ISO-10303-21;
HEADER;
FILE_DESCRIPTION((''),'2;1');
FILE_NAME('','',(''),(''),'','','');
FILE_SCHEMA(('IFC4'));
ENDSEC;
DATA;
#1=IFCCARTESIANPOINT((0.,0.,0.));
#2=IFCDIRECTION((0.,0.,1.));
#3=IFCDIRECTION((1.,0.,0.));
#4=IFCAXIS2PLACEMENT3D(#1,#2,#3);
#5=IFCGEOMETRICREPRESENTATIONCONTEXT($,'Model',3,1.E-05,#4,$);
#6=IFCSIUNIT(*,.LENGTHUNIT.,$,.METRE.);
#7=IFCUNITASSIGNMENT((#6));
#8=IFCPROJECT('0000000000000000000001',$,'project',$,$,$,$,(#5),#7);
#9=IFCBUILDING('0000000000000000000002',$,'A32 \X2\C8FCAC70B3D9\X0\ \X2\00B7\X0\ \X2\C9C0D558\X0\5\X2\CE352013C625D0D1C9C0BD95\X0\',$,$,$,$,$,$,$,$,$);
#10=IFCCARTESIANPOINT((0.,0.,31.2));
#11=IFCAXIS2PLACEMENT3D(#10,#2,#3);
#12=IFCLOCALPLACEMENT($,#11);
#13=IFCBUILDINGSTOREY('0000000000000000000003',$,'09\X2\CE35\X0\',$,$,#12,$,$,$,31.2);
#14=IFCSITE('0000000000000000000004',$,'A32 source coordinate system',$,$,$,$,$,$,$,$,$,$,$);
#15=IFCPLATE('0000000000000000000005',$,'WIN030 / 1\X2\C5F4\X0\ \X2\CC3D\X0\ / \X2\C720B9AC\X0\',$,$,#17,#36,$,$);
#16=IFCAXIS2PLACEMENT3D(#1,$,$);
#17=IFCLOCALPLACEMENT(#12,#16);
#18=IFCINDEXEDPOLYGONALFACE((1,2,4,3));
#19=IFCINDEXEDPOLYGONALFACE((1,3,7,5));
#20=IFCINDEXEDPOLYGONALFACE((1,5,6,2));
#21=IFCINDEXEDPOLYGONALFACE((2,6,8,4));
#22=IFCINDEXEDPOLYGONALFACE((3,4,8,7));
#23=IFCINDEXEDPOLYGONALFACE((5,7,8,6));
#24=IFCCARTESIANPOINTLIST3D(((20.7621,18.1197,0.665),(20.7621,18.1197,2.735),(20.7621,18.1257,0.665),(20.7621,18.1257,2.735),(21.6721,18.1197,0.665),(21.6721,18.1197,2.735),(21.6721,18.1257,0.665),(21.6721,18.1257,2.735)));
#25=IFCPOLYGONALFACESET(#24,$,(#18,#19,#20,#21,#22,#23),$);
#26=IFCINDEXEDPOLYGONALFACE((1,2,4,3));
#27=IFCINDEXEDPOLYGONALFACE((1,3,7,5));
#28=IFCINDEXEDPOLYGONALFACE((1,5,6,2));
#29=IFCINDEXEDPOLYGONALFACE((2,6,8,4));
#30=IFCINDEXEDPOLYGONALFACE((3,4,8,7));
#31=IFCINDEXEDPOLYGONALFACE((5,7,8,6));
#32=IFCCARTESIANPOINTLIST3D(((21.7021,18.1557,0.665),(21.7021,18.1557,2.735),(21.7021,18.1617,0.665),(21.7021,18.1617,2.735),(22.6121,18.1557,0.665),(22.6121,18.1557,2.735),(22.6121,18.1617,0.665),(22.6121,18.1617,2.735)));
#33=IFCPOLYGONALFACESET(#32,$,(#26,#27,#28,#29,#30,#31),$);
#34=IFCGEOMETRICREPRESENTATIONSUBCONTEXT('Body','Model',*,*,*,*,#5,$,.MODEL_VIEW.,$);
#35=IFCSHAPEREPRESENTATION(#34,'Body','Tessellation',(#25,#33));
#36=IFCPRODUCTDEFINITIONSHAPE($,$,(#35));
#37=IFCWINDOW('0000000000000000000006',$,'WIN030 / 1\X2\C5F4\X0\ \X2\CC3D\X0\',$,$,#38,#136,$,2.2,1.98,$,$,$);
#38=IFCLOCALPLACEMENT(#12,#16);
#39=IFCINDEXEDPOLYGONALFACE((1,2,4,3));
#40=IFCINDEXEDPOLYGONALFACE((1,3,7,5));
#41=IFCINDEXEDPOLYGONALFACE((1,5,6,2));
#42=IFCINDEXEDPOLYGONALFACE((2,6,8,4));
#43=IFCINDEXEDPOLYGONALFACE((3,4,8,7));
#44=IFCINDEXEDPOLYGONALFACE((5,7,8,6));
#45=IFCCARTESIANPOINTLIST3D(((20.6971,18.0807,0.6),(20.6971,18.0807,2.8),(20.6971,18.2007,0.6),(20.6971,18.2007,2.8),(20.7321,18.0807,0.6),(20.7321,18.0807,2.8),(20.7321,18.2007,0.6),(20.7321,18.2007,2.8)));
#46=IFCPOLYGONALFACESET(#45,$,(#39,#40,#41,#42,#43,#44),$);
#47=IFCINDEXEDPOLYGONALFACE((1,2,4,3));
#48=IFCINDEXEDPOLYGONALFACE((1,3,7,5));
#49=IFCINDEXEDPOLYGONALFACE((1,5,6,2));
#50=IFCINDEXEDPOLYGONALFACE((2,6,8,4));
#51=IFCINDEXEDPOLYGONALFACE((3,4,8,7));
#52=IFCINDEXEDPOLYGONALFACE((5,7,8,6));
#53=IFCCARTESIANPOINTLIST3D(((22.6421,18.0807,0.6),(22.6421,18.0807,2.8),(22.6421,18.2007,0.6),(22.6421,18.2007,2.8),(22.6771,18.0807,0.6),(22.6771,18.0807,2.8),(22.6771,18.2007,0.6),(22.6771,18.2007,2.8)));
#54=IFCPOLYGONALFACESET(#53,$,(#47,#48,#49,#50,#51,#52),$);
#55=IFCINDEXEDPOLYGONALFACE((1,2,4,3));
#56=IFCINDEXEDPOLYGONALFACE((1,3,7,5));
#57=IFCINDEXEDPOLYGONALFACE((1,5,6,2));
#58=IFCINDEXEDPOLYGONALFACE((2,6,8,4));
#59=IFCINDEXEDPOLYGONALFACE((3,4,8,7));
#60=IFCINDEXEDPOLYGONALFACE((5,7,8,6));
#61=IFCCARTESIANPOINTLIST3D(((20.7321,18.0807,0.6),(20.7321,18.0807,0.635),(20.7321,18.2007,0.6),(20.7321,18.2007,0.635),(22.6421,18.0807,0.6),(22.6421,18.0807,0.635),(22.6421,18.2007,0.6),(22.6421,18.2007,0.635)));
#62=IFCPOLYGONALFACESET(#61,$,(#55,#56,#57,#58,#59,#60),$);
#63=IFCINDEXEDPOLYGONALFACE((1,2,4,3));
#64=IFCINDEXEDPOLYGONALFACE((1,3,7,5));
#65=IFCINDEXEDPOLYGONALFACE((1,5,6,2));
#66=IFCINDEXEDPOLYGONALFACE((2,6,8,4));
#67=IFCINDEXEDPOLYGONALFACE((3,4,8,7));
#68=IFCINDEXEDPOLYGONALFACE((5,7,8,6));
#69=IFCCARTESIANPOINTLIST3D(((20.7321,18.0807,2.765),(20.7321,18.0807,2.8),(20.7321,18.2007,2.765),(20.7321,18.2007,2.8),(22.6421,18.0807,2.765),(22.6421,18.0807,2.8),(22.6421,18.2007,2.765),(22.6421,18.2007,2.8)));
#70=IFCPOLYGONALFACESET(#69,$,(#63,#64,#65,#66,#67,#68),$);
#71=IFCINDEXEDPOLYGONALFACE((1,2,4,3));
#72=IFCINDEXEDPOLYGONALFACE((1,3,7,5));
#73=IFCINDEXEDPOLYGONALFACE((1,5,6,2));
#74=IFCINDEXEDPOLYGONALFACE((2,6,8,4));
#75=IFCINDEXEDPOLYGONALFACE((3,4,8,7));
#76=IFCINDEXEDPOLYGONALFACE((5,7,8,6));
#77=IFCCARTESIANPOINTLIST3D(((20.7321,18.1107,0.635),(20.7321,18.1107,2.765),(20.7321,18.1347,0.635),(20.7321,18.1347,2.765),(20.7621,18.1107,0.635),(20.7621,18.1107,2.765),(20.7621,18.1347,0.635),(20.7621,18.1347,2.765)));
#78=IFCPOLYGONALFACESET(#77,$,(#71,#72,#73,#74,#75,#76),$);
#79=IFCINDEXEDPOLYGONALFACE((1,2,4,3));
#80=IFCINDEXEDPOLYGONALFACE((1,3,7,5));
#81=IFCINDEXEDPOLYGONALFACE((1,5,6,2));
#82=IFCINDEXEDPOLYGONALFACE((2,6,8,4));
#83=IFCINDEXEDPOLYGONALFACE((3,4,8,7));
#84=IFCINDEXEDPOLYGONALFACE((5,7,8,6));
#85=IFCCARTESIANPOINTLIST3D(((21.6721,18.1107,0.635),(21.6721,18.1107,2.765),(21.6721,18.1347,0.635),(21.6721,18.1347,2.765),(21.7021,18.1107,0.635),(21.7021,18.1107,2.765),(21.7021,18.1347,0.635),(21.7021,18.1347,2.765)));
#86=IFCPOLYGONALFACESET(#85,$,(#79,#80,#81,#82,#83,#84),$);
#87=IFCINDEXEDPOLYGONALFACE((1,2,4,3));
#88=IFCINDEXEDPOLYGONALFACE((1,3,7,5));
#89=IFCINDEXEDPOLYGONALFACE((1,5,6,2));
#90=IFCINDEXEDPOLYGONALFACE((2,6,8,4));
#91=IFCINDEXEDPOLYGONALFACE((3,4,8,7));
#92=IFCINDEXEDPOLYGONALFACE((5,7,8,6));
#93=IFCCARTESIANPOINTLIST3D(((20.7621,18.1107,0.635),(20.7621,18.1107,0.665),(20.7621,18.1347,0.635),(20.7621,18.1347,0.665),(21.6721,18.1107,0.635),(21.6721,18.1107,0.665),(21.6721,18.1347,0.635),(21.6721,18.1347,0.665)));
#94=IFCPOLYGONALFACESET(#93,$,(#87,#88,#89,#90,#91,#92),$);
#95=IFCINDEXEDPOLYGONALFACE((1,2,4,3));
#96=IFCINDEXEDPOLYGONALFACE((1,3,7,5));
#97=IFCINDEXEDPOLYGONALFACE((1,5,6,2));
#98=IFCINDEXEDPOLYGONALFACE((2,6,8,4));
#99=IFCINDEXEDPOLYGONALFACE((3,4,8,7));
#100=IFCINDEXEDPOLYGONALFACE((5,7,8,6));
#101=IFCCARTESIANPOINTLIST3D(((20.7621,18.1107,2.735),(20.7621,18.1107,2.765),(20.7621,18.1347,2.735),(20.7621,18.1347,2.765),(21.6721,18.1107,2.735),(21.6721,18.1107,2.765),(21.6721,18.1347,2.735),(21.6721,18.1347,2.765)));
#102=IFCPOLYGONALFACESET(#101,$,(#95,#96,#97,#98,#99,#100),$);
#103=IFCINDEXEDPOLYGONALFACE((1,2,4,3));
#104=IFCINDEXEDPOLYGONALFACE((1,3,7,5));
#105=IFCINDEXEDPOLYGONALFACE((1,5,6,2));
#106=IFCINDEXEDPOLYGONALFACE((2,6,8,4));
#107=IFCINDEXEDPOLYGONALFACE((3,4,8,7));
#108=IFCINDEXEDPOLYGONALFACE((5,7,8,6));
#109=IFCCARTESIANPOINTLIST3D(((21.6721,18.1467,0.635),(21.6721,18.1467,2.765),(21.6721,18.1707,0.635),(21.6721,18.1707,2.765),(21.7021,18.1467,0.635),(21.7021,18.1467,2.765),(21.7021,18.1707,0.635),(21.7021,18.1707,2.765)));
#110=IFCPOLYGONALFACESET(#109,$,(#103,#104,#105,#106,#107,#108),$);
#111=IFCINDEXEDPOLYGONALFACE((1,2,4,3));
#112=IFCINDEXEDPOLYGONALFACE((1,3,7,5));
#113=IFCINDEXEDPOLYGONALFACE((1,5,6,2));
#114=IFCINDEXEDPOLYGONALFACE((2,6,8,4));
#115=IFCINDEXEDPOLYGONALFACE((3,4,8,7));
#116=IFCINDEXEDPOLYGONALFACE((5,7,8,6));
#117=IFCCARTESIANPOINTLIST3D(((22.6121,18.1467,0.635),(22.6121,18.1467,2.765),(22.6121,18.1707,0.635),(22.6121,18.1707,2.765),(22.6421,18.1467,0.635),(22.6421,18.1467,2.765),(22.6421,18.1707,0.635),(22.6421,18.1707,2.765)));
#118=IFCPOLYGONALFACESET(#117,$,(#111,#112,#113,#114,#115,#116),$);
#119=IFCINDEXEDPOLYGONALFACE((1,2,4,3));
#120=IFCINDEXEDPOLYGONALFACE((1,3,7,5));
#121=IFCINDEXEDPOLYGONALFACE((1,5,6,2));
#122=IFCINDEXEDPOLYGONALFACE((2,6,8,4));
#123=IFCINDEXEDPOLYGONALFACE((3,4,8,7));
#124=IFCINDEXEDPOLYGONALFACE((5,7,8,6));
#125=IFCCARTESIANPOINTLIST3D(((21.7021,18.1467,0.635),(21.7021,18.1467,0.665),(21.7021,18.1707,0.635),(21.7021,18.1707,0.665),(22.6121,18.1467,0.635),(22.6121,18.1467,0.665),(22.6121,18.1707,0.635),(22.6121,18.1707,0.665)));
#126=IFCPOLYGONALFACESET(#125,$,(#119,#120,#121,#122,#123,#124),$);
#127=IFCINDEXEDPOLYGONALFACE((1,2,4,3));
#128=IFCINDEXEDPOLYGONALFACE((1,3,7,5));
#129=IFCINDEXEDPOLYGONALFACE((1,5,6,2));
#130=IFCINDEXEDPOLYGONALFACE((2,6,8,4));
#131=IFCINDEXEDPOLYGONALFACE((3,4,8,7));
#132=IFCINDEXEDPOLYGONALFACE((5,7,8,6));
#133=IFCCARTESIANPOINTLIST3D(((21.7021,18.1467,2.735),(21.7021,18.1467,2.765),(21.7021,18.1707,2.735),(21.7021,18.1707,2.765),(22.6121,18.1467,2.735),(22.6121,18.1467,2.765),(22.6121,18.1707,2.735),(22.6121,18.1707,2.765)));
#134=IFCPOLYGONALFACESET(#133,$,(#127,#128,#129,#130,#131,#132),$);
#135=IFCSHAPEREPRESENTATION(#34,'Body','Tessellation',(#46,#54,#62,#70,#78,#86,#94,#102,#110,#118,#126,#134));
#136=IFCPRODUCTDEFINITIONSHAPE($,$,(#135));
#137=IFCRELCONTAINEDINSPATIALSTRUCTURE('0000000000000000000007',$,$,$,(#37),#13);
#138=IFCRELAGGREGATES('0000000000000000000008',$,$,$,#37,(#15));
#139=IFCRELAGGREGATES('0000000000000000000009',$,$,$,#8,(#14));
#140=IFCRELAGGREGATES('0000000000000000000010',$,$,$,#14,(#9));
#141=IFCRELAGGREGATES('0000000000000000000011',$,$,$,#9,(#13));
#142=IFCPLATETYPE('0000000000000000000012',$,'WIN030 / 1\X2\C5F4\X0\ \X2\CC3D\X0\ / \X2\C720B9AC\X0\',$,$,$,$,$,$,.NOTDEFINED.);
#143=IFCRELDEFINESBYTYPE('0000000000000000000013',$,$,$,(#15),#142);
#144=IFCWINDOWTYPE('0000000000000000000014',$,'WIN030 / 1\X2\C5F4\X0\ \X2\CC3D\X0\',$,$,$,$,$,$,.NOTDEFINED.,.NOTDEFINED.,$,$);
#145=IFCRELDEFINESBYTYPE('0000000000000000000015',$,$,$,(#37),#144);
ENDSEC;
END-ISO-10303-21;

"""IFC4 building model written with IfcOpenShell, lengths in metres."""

from ifc_helpers import new_model, si_unit, frame, origin, origin_with_axes, place, context, subcontext, project, spatial, polyline, outline, extrude, source, transform, mapped, type_object, type_shapes, element, aggregate, save


model = new_model("IFC4")

# Units and contexts
model_context = context("Model", 3, precision=1e-05, world=origin_with_axes())
body_context = subcontext(model_context, "Body", "Model", "MODEL_VIEW")
ifc_project = project(units=[si_unit("LENGTHUNIT", "METRE")], contexts=[model_context])

# Plate
storey_placement = place(None, frame((0.0, 0.0, 31.2), z_axis=(0.0, 0.0, 1.0), x_axis=(1.0, 0.0, 0.0)))
plate_type_1 = type_object("IfcPlateType", Name="WIN030 / 1열 창 / 유리", PredefinedType="NOTDEFINED")
shared_shape_1 = source(origin(), body_context, "Body", "SweptSolid", [
    extrude(outline(polyline([(20.7621, 18.1197), (20.7621, 18.1257), (21.6721, 18.1257), (21.6721, 18.1197), (20.7621, 18.1197)])), frame((0.0, 0.0, 0.665)), (0.0, 0.0, 1.0), 2.07),
    extrude(outline(polyline([(21.7021, 18.1557), (21.7021, 18.1617), (22.6121, 18.1617), (22.6121, 18.1557), (21.7021, 18.1557)])), frame((0.0, 0.0, 0.665)), (0.0, 0.0, 1.0), 2.07),
])
type_shapes(plate_type_1, [shared_shape_1])
window_1_placement = place(storey_placement, origin_with_axes())
plate_1_placement = place(window_1_placement, origin_with_axes())
plate_1 = element("IfcPlate", 1, at=plate_1_placement, type_object=plate_type_1, Name="WIN030 / 1열 창 / 유리", context=body_context, shape_type="MappedRepresentation", body=[
    mapped(shared_shape_1, transform((0.0, 0.0, 0.0), scale=1.0)),
])

# Site, building, storey
site = spatial("IfcSite", under=ifc_project, Name="A32 source coordinate system")
building = spatial("IfcBuilding", under=site, Name="A32 주거동 · 지하5층–옥탑지붕")
storey = spatial("IfcBuildingStorey", under=building, at=storey_placement, Name="09층", Elevation=31.2)

# Window
window_type_1 = type_object("IfcWindowType", Name="WIN030 / 1열 창", PartitioningType="NOTDEFINED", PredefinedType="NOTDEFINED")
shared_shape_2 = source(origin(), body_context, "Body", "SweptSolid", [
    extrude(outline(polyline([(20.6971, 18.0807), (20.6971, 18.2007), (20.7321, 18.2007), (20.7321, 18.0807), (20.6971, 18.0807)])), frame((0.0, 0.0, 0.6)), (0.0, 0.0, 1.0), 2.2),
    extrude(outline(polyline([(22.6421, 18.0807), (22.6421, 18.2007), (22.6771, 18.2007), (22.6771, 18.0807), (22.6421, 18.0807)])), frame((0.0, 0.0, 0.6)), (0.0, 0.0, 1.0), 2.2),
    extrude(outline(polyline([(20.7321, 18.0807), (20.7321, 18.2007), (22.6421, 18.2007), (22.6421, 18.0807), (20.7321, 18.0807)])), frame((0.0, 0.0, 0.6)), (0.0, 0.0, 1.0), 0.035),
    extrude(outline(polyline([(20.7321, 18.0807), (20.7321, 18.2007), (22.6421, 18.2007), (22.6421, 18.0807), (20.7321, 18.0807)])), frame((0.0, 0.0, 2.765)), (0.0, 0.0, 1.0), 0.035),
    extrude(outline(polyline([(20.7321, 18.1107), (20.7321, 18.1347), (20.7621, 18.1347), (20.7621, 18.1107), (20.7321, 18.1107)])), frame((0.0, 0.0, 0.635)), (0.0, 0.0, 1.0), 2.13),
    extrude(outline(polyline([(21.6721, 18.1107), (21.6721, 18.1347), (21.7021, 18.1347), (21.7021, 18.1107), (21.6721, 18.1107)])), frame((0.0, 0.0, 0.635)), (0.0, 0.0, 1.0), 2.13),
    extrude(outline(polyline([(20.7621, 18.1107), (20.7621, 18.1347), (21.6721, 18.1347), (21.6721, 18.1107), (20.7621, 18.1107)])), frame((0.0, 0.0, 0.635)), (0.0, 0.0, 1.0), 0.03),
    extrude(outline(polyline([(20.7621, 18.1107), (20.7621, 18.1347), (21.6721, 18.1347), (21.6721, 18.1107), (20.7621, 18.1107)])), frame((0.0, 0.0, 2.735)), (0.0, 0.0, 1.0), 0.03),
    extrude(outline(polyline([(21.6721, 18.1467), (21.6721, 18.1707), (21.7021, 18.1707), (21.7021, 18.1467), (21.6721, 18.1467)])), frame((0.0, 0.0, 0.635)), (0.0, 0.0, 1.0), 2.13),
    extrude(outline(polyline([(22.6121, 18.1467), (22.6121, 18.1707), (22.6421, 18.1707), (22.6421, 18.1467), (22.6121, 18.1467)])), frame((0.0, 0.0, 0.635)), (0.0, 0.0, 1.0), 2.13),
    extrude(outline(polyline([(21.7021, 18.1467), (21.7021, 18.1707), (22.6121, 18.1707), (22.6121, 18.1467), (21.7021, 18.1467)])), frame((0.0, 0.0, 0.635)), (0.0, 0.0, 1.0), 0.03),
    extrude(outline(polyline([(21.7021, 18.1467), (21.7021, 18.1707), (22.6121, 18.1707), (22.6121, 18.1467), (21.7021, 18.1467)])), frame((0.0, 0.0, 2.735)), (0.0, 0.0, 1.0), 0.03),
])
type_shapes(window_type_1, [shared_shape_2])
window_1 = element("IfcWindow", 2, at=window_1_placement, inside=storey, type_object=window_type_1, Name="WIN030 / 1열 창", OverallHeight=2.2, OverallWidth=1.98, context=body_context, shape_type="MappedRepresentation", body=[
    mapped(shared_shape_2, transform((0.0, 0.0, 0.0), scale=1.0)),
])
aggregate(window_1, [plate_1])

save(model, "model.ifc")
